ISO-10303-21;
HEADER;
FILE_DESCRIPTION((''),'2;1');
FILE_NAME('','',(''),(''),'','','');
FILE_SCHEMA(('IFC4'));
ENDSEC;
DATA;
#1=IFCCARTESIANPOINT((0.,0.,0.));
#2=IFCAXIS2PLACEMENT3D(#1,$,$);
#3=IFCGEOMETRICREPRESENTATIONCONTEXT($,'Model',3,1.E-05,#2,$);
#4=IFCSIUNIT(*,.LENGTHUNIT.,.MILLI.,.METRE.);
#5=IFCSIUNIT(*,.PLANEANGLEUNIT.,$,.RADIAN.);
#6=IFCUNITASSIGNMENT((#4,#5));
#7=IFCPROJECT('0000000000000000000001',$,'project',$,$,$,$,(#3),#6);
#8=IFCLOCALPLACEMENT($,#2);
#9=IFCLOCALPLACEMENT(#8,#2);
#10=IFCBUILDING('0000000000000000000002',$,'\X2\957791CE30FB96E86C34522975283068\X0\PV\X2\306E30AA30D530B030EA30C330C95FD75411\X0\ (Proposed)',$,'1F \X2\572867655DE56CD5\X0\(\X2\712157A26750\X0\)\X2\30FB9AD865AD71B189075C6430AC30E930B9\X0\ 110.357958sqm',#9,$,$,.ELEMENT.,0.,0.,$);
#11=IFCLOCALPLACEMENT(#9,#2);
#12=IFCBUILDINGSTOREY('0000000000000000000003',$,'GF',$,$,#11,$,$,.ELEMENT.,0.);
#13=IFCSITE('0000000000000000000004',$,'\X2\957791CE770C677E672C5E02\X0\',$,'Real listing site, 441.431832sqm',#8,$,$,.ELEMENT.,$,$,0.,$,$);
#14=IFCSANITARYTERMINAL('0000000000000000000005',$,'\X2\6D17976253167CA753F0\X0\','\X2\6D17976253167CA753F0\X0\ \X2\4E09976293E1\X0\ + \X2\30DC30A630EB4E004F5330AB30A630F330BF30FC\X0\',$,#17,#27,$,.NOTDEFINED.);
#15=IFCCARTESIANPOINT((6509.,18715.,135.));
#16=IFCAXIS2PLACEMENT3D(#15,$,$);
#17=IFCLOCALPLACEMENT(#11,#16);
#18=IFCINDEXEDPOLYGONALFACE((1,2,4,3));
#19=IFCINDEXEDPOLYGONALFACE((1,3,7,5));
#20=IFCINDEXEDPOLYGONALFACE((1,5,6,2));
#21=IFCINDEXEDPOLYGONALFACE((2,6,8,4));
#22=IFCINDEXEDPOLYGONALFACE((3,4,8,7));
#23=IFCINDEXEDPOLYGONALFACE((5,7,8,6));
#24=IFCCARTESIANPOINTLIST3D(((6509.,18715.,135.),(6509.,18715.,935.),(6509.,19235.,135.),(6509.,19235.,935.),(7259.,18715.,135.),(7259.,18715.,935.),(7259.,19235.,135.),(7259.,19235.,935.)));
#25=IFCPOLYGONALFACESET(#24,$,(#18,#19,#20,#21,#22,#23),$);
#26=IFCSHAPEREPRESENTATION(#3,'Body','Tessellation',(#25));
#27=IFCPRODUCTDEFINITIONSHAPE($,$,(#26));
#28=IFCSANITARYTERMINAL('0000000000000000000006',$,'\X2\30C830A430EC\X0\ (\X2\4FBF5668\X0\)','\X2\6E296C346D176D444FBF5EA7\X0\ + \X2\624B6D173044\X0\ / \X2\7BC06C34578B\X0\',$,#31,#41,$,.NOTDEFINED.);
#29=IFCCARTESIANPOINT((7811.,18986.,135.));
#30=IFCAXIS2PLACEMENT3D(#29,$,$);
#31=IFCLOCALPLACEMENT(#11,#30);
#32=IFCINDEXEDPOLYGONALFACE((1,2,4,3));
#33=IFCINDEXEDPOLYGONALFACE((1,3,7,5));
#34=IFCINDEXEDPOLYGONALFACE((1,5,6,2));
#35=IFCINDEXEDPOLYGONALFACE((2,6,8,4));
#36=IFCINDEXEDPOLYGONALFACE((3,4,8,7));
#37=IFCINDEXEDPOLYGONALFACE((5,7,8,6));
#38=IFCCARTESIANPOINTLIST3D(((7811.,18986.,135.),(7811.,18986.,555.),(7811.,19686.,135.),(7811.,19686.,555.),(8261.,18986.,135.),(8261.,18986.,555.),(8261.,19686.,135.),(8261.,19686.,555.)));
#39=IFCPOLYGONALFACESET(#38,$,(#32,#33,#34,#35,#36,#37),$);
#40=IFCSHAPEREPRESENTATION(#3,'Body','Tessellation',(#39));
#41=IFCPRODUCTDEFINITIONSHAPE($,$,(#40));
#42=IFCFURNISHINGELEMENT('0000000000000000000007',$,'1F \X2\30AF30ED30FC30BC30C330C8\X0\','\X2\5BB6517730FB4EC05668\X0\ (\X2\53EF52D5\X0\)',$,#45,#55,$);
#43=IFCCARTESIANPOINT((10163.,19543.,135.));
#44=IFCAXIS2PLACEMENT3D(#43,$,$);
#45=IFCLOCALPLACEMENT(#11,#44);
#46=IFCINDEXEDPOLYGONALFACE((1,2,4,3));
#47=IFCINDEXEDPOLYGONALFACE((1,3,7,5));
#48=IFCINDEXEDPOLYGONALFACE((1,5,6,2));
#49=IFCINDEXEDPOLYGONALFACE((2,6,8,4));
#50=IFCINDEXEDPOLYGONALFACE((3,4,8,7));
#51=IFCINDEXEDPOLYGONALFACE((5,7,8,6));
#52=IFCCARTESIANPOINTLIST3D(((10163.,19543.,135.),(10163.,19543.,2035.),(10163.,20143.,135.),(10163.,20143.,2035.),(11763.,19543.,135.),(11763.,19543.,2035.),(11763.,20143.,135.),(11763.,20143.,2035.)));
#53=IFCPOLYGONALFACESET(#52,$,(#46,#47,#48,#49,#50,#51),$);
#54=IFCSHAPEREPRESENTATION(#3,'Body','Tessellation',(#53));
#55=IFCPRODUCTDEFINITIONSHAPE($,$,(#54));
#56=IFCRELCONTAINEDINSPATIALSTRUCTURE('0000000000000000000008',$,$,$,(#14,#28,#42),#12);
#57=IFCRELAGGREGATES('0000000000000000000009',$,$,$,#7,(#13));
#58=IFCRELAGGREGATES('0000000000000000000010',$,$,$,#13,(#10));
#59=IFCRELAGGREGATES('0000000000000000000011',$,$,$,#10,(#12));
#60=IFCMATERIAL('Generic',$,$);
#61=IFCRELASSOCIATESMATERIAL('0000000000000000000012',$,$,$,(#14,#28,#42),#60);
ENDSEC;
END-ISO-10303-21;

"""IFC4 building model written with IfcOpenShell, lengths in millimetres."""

from ifc_helpers import new_model, si_unit, frame, frame_2d, origin, place, context, project, spatial, rectangle, extrude, material, element, save


model = new_model("IFC4")

# Units and contexts
model_context = context("Model", 3, precision=1e-05, world=origin())
ifc_project = project(units=[si_unit("LENGTHUNIT", "METRE", prefix="MILLI"), si_unit("PLANEANGLEUNIT", "RADIAN")], contexts=[model_context])

# Site, building, storey
site_placement = place(None, origin())
site = spatial("IfcSite", under=ifc_project, at=site_placement, Name="長野県松本市", ObjectType="Real listing site, 441.431832sqm", CompositionType="ELEMENT", RefElevation=0.0)
building_placement = place(site_placement, origin())
building = spatial("IfcBuilding", under=site, at=building_placement, Name="長野・雨水利用とPVのオフグリッド志向 (Proposed)", ObjectType="1F 在来工法(無垢材)・高断熱複層ガラス 110.357958sqm", CompositionType="ELEMENT", ElevationOfRefHeight=0.0, ElevationOfTerrain=0.0)
storey_placement = place(building_placement, origin())
storey = spatial("IfcBuildingStorey", under=building, at=storey_placement, Name="GF", CompositionType="ELEMENT", Elevation=0.0)

# Shared definitions
ifc_material_1 = material(Name="Generic")

# Sanitary terminals
sanitary_terminal_1_placement = place(storey_placement, frame((6509.0, 18715.0, 135.0)))
element("IfcSanitaryTerminal", 1, at=sanitary_terminal_1_placement, inside=storey, material=ifc_material_1, Name="洗面化粧台", Description="洗面化粧台 三面鏡 + ボウル一体カウンター", PredefinedType="NOTDEFINED", context=model_context, shape_type="SweptSolid", body=[
    extrude(rectangle(XDim=750.0, YDim=520.0, at=frame_2d((375.0, 260.0))), frame((6509.0, 18715.0, 135.0)), (0.0, 0.0, 1.0), 800.0),
])
sanitary_terminal_2_placement = place(storey_placement, frame((7811.0, 18986.0, 135.0)))
element("IfcSanitaryTerminal", 2, at=sanitary_terminal_2_placement, inside=storey, material=ifc_material_1, Name="トイレ (便器)", Description="温水洗浄便座 + 手洗い / 節水型", PredefinedType="NOTDEFINED", context=model_context, shape_type="SweptSolid", body=[
    extrude(rectangle(XDim=450.0, YDim=700.0, at=frame_2d((225.0, 350.0))), frame((7811.0, 18986.0, 135.0)), (0.0, 0.0, 1.0), 420.0),
])

# Furnishing element
furnishing_placement = place(storey_placement, frame((10163.0, 19543.0, 135.0)))
element("IfcFurnishingElement", 3, at=furnishing_placement, inside=storey, material=ifc_material_1, Name="1F クローゼット", Description="家具・什器 (可動)", context=model_context, shape_type="SweptSolid", body=[
    extrude(rectangle(XDim=1600.0, YDim=600.0, at=frame_2d((800.0, 300.0))), frame((10163.0, 19543.0, 135.0)), (0.0, 0.0, 1.0), 1900.0),
])

save(model, "model.ifc")
